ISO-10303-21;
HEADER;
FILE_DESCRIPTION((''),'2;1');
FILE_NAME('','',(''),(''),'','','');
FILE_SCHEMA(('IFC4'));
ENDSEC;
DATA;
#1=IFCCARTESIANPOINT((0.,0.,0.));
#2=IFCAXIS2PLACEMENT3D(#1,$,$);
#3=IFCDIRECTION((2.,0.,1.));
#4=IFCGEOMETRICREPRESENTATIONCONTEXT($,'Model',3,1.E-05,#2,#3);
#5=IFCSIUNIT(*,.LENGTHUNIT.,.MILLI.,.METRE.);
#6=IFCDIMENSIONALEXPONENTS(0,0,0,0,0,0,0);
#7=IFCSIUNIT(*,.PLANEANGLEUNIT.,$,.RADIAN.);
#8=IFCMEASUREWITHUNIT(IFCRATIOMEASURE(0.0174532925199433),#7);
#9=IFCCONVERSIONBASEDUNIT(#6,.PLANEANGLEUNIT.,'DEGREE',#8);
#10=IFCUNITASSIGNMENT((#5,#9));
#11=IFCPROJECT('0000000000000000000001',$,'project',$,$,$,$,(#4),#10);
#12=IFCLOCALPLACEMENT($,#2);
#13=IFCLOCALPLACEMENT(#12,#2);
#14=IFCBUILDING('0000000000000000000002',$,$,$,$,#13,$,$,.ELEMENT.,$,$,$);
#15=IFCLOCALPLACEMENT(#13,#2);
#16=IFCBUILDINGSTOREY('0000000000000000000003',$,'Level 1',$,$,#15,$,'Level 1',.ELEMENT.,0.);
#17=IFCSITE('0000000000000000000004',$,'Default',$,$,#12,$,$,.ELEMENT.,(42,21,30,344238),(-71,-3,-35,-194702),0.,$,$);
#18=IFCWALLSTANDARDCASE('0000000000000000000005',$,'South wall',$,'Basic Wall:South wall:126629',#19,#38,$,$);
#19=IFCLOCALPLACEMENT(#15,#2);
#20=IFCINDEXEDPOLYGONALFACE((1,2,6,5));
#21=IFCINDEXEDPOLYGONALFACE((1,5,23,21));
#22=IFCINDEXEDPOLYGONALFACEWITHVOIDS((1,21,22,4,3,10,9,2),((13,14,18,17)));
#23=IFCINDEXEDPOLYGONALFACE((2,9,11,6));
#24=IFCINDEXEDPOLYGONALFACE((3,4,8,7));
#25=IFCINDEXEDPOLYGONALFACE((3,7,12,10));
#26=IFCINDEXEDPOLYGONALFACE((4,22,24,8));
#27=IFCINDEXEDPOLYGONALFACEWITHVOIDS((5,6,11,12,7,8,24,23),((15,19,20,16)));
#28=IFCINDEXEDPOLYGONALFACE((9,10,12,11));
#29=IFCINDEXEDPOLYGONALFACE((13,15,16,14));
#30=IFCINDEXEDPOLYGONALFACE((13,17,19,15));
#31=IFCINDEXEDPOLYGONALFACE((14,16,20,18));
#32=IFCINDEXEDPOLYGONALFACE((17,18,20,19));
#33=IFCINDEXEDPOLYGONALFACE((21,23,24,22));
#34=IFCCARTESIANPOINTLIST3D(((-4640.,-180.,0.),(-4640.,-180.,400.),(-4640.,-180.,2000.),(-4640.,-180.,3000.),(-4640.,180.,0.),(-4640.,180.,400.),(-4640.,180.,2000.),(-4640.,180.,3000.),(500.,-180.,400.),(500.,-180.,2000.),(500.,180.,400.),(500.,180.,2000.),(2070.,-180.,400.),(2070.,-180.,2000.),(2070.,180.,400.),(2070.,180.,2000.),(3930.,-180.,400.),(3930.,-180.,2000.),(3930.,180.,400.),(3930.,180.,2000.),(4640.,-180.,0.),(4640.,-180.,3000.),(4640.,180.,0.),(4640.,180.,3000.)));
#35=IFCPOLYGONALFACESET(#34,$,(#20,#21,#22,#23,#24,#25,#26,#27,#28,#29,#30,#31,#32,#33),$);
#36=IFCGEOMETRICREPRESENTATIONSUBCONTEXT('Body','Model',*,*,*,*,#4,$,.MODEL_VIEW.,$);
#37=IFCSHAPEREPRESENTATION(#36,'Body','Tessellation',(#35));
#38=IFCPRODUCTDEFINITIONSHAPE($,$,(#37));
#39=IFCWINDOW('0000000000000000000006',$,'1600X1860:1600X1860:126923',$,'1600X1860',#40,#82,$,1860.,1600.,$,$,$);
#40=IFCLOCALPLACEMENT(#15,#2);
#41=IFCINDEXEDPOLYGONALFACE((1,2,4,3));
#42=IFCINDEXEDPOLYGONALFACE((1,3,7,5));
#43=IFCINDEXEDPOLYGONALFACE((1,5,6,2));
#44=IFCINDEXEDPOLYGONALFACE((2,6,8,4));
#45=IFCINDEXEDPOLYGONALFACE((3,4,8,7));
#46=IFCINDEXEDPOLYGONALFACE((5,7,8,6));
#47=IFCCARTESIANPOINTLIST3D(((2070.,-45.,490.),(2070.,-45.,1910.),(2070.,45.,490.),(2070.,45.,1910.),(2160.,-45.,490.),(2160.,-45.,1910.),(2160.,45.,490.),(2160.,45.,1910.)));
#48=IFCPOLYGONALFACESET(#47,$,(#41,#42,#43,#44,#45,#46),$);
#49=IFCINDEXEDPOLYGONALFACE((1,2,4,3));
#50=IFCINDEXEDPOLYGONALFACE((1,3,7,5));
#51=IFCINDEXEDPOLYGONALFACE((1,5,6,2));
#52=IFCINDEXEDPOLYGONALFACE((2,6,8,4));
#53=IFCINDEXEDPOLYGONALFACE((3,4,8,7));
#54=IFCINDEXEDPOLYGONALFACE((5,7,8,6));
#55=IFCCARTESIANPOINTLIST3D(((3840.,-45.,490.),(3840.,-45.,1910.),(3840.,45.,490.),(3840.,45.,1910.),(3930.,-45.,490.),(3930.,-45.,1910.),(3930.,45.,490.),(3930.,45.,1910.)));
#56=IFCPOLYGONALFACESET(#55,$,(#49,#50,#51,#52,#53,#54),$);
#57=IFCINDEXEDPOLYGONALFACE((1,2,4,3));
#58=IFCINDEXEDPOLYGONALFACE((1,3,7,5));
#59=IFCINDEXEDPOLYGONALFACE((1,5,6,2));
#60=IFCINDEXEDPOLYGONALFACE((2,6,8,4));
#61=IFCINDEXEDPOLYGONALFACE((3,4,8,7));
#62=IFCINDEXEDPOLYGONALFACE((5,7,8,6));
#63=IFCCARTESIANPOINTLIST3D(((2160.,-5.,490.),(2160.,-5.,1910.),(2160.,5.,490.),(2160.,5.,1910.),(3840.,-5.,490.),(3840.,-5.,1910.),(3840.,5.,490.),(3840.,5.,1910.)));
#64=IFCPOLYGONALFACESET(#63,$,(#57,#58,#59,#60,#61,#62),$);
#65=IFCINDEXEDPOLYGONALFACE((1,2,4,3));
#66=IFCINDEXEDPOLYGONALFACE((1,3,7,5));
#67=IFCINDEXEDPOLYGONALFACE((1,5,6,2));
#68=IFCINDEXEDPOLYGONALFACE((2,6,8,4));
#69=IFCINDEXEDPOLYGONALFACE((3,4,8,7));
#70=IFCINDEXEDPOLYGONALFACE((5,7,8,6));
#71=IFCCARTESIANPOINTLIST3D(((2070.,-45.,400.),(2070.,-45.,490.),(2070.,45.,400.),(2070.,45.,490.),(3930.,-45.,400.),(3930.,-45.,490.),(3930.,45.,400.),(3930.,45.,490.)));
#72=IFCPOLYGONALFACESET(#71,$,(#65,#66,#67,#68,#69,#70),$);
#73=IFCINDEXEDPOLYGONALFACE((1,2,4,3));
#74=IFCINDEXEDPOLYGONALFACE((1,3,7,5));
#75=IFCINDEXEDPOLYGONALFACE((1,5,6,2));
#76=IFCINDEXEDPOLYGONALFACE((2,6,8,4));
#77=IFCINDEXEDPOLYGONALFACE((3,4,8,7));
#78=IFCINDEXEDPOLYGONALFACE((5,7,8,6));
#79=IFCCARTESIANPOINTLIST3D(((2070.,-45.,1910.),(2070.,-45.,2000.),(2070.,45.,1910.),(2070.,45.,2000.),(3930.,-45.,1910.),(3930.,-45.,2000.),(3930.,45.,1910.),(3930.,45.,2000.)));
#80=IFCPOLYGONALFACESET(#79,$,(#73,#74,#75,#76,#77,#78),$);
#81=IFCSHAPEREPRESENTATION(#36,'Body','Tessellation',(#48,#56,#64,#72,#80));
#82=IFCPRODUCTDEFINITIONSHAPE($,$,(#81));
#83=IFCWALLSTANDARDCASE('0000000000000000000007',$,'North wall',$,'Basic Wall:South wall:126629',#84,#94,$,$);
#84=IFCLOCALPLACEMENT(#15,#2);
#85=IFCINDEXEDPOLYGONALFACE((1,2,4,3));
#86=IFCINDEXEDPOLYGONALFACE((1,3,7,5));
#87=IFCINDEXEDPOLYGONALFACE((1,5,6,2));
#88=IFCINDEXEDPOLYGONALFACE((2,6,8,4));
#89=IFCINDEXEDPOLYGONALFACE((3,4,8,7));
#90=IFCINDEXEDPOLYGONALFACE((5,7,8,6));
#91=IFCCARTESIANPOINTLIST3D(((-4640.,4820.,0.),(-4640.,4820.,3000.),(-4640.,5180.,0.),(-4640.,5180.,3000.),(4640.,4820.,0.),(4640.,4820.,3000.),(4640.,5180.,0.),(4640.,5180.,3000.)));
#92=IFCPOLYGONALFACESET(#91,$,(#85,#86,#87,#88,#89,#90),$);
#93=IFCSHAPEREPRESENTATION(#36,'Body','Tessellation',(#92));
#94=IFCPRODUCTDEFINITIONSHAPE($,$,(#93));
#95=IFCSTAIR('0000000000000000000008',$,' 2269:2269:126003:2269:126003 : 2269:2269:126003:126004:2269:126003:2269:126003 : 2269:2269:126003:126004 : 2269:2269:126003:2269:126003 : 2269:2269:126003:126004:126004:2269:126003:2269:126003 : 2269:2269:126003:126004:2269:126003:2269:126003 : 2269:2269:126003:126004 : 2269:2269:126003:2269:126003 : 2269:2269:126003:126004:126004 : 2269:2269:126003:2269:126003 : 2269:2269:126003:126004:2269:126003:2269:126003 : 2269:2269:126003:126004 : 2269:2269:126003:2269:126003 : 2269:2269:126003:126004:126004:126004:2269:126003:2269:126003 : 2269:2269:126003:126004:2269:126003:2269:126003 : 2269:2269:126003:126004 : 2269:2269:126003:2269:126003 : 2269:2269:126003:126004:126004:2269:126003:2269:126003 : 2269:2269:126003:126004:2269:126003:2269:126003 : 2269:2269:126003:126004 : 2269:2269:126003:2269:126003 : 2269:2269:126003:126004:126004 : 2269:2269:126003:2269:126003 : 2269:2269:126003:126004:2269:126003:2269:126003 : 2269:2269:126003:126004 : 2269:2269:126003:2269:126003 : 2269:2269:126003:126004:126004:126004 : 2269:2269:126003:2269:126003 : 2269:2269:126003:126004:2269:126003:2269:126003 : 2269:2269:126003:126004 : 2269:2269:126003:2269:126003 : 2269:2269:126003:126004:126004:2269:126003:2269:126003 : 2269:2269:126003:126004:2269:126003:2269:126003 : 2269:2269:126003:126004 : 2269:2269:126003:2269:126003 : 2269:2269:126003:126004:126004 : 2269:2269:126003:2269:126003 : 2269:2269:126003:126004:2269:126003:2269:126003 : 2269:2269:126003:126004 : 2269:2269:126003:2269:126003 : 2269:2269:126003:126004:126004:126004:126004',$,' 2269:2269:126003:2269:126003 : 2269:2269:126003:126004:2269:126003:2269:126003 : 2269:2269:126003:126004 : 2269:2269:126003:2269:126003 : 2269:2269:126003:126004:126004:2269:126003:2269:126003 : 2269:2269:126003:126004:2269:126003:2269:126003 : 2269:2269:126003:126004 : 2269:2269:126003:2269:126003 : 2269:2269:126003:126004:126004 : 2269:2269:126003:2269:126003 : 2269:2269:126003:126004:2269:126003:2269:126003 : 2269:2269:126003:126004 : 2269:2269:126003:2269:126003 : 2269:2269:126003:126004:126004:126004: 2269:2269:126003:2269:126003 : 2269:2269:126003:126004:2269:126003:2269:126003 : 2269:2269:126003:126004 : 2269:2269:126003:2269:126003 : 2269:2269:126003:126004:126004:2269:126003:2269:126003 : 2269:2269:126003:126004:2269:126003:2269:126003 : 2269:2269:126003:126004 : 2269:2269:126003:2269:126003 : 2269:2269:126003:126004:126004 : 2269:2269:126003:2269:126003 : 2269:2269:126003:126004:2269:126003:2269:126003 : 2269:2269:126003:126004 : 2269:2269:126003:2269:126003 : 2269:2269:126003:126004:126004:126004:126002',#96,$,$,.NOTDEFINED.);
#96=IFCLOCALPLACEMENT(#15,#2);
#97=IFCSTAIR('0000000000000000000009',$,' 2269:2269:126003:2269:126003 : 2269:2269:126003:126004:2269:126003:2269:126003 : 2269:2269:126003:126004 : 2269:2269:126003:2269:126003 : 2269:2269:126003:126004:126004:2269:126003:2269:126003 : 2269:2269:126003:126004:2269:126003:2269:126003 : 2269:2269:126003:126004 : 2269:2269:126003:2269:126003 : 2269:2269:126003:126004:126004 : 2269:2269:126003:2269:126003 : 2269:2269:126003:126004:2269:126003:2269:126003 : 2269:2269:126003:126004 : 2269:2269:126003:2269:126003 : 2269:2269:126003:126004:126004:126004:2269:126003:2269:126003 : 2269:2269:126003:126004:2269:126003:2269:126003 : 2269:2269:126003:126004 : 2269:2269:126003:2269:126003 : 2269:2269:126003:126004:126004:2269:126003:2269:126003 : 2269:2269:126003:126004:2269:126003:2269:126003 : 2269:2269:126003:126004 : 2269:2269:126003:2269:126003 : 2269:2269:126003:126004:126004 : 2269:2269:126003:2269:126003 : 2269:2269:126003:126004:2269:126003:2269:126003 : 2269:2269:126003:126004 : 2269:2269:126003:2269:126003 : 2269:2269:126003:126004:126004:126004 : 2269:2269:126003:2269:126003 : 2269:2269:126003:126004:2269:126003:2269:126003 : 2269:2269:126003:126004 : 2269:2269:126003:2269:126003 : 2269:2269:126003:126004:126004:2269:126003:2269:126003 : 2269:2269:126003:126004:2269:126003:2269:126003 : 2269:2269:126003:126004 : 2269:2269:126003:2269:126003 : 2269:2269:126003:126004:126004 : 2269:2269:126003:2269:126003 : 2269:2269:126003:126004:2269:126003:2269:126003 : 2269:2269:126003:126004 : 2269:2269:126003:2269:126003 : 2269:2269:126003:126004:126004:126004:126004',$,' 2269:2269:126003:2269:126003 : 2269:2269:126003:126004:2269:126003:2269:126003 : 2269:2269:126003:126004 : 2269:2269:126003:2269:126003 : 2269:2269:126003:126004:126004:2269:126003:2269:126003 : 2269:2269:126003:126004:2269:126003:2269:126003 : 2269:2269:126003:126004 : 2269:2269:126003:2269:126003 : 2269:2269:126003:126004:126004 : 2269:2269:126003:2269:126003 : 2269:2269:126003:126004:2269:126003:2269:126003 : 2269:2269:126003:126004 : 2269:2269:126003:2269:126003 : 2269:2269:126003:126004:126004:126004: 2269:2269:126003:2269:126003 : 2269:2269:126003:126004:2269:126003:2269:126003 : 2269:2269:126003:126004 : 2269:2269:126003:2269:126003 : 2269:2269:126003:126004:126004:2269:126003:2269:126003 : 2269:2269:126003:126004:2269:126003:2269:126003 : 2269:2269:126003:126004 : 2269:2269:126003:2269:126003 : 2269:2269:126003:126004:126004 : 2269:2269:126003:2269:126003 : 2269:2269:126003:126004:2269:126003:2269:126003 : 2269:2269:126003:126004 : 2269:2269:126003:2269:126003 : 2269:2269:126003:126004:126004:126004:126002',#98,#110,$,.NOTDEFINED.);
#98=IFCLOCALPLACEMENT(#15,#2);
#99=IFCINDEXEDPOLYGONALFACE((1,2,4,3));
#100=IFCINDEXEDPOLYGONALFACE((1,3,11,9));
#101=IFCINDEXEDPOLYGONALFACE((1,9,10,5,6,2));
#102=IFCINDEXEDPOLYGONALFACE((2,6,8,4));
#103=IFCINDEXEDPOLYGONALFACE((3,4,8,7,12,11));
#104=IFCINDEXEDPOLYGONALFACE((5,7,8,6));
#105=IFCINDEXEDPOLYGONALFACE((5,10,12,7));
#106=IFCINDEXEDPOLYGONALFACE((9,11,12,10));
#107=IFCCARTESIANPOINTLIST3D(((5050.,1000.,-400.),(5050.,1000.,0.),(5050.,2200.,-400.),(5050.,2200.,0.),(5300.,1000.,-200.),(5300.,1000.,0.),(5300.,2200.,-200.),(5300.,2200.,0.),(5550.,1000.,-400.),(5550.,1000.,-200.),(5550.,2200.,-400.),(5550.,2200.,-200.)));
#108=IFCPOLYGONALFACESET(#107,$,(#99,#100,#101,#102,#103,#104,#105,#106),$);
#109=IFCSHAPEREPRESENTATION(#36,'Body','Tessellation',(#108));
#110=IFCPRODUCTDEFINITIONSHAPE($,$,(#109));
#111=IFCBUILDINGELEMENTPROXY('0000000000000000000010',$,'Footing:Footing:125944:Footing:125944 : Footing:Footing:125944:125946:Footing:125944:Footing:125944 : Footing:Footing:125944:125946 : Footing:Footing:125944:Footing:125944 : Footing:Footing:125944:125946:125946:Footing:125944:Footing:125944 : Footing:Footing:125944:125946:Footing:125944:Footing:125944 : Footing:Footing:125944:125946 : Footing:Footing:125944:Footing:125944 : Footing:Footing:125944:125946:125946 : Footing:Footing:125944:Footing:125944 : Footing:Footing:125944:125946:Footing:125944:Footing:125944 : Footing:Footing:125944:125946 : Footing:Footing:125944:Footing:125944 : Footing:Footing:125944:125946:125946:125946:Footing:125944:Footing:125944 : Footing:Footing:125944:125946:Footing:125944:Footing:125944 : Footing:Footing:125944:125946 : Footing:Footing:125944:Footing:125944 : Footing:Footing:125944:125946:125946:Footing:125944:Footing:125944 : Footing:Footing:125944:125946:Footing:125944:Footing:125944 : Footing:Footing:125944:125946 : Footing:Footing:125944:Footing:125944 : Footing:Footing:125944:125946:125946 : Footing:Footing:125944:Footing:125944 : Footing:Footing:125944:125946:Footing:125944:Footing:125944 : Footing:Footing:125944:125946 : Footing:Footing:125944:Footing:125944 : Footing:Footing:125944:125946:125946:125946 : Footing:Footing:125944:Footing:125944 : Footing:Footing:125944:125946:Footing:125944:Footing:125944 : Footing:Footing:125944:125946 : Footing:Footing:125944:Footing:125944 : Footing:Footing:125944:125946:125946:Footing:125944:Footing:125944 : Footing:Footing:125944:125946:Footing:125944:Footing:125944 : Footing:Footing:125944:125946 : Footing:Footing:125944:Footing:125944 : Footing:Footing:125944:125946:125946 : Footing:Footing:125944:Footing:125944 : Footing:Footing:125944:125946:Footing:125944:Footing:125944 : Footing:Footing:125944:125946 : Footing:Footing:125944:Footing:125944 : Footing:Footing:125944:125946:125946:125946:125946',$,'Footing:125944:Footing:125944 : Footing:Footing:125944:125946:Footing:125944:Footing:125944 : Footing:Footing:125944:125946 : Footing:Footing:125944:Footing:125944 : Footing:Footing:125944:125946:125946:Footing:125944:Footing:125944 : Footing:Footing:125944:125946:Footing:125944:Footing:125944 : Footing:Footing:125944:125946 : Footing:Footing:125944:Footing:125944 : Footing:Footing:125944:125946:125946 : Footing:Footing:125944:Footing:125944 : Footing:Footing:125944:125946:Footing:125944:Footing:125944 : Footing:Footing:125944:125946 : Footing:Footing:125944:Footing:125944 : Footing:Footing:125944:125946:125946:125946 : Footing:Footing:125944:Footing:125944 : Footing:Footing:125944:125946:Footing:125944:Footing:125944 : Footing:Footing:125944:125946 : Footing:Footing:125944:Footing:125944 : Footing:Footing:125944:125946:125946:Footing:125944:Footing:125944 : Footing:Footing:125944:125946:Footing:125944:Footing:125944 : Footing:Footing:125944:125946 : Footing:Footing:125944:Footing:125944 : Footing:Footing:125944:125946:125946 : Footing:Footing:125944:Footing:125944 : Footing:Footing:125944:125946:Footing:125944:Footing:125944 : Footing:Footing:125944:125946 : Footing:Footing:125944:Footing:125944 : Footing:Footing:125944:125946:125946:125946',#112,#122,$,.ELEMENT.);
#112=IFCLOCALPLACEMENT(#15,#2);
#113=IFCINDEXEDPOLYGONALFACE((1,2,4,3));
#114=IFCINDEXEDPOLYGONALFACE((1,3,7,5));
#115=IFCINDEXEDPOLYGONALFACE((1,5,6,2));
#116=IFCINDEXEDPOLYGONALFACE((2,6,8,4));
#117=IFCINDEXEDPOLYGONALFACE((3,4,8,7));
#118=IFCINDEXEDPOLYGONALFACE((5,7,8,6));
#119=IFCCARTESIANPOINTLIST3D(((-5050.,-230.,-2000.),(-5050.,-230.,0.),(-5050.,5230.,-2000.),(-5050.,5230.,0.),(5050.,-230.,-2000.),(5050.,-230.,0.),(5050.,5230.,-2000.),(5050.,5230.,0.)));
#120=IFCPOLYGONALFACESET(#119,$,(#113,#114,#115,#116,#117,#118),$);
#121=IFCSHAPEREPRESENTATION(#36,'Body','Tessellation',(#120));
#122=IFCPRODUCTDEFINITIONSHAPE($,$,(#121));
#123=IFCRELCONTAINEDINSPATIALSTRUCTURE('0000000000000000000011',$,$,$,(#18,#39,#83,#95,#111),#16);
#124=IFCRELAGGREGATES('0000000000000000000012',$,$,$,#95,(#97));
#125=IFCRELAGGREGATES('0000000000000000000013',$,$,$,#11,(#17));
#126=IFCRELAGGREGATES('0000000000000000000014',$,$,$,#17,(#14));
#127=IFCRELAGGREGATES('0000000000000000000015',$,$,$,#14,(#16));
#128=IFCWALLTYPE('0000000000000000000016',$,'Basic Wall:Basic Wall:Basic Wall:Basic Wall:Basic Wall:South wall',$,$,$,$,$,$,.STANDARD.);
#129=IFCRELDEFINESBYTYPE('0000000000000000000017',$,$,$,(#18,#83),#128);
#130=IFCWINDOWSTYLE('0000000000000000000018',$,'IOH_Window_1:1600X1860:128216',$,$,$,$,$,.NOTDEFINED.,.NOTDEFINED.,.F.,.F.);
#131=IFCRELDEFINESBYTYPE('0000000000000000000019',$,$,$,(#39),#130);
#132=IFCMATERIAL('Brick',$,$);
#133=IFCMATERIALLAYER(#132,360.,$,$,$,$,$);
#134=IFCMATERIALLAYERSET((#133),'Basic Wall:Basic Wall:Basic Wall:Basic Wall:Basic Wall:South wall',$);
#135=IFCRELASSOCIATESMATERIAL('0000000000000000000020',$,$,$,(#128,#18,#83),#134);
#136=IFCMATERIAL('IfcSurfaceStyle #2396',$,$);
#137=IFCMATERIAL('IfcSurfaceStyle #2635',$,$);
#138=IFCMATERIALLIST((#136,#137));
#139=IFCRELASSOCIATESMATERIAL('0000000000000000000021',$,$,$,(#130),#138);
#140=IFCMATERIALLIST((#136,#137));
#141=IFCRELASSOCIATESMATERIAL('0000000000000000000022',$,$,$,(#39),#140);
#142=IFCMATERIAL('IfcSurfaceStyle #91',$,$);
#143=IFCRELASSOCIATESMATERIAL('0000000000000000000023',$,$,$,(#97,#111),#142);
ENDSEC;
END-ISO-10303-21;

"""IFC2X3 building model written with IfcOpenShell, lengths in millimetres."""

from ifc_helpers import new_model, entity, si_unit, converted_unit, direction, frame, frame_2d, origin, origin_2d_with_axis, place, context, subcontext, project, spatial, polyline, rectangle, outline, extrude, source, transform, mapped, material, material_list, layer, layer_set, layer_usage, type_object, type_shapes, element, fill, aggregate, save


model = new_model("IFC2X3")

# Units and contexts
model_context = context("Model", 3, precision=1e-05, world=origin(), true_north=direction((2.0, 0.0, 1.0)))
body_context = subcontext(model_context, "Body", "Model", "MODEL_VIEW")
ifc_project = project(units=[si_unit("LENGTHUNIT", "METRE", prefix="MILLI"), converted_unit("PLANEANGLEUNIT", "DEGREE", entity("IfcRatioMeasure", 0.0174532925199433), si_unit("PLANEANGLEUNIT", "RADIAN"), dimensions=[0, 0, 0, 0, 0, 0, 0])], contexts=[model_context])

# Site, building, storey
site_placement = place(None, origin())
site = spatial("IfcSite", under=ifc_project, at=site_placement, Name="Default", CompositionType="ELEMENT", RefLatitude=(42, 21, 30, 344238), RefLongitude=(-71, -3, -35, -194702), RefElevation=0.0)
building_placement = place(site_placement, origin())
building = spatial("IfcBuilding", under=site, at=building_placement, CompositionType="ELEMENT")
storey_placement = place(building_placement, origin())
storey = spatial("IfcBuildingStorey", under=building, at=storey_placement, Name="Level 1", LongName="Level 1", CompositionType="ELEMENT", Elevation=0.0)

# Shared definitions
ifc_material_1 = material(Name="IfcSurfaceStyle #2396")

# Shared definitions
ifc_material_2 = material(Name="Brick")
ifc_layer = layer(ifc_material_2, 360.0)
ifc_layer_set = layer_set([ifc_layer], Name="Basic Wall:Basic Wall:Basic Wall:Basic Wall:Basic Wall:South wall")
wall_type = type_object("IfcWallType", Name="Basic Wall:Basic Wall:Basic Wall:Basic Wall:Basic Wall:South wall", PredefinedType="STANDARD", material=ifc_layer_set)

# Wall, openings, window
ifc_layer_usage_1 = layer_usage(ifc_layer_set, "AXIS2", "NEGATIVE", 180.0)
wall_1_placement = place(storey_placement, frame((4640.0, 0.0, 0.0), z_axis=(0.0, 0.0, 1.0), x_axis=(-1.0, 0.0, 0.0)))
wall_1 = element("IfcWallStandardCase", 1, at=wall_1_placement, inside=storey, type_object=wall_type, material=ifc_layer_usage_1, Name="South wall", ObjectType="Basic Wall:South wall:126629", context=body_context, shape_type="SweptSolid", body=[
    extrude(rectangle(XDim=9280.0, YDim=360.0, at=frame_2d((4640.0, 0.0), x_axis=(-1.0, 0.0))), origin(), (0.0, 0.0, 1.0), 3000.0),
])
opening_1_placement = place(wall_1_placement, frame((10140.0, 180.0, 400.0)))
element("IfcOpeningElement", 2, at=opening_1_placement, cuts=wall_1, ObjectType="Opening", context=body_context, shape_type="SweptSolid", body=[
    extrude(rectangle(XDim=1600.0, YDim=6000.0, at=origin_2d_with_axis()), frame((-3000.0, -360.0, 800.0), z_axis=(0.0, 1.0, 0.0), x_axis=(0.0, 0.0, -1.0)), (0.0, 0.0, 1.0), 360.0),
])
opening_2_placement = place(wall_1_placement, frame((2570.0, 183.6, 400.0), z_axis=(0.0, 0.0, 1.0), x_axis=(-1.0, 0.0, 0.0)))
opening_2 = element("IfcOpeningElement", 3, at=opening_2_placement, cuts=wall_1, ObjectType="Opening", context=body_context, shape_type="SweptSolid", body=[
    extrude(rectangle(XDim=1600.0, YDim=1860.0, at=frame_2d((0.0, 0.0), x_axis=(1.0, 0.0))), frame((930.0, 367.2, 800.0), z_axis=(0.0, -1.0, 0.0), x_axis=(0.0, 0.0, -1.0)), (0.0, 0.0, 1.0), 367.2),
])
ifc_material_3 = material(Name="IfcSurfaceStyle #2635")
ifc_material_list_1 = material_list([ifc_material_1, ifc_material_3])
ifc_material_list_2 = material_list([ifc_material_1, ifc_material_3])
window_style_1 = type_object("IfcWindowStyle", Name="IOH_Window_1:1600X1860:128216", ConstructionType="NOTDEFINED", OperationType="NOTDEFINED", ParameterTakesPrecedence=False, Sizeable=False, material=ifc_material_list_2)
shared_shape_1 = source(origin(), body_context, "Body", "SweptSolid", [
    extrude(rectangle(XDim=90.0, YDim=90.0, at=frame_2d((0.0, 0.0), x_axis=(1.0, 0.0))), frame((45.0, 183.6, 90.0), z_axis=(0.0, 0.0, 1.0), x_axis=(-1.0, 0.0, 0.0)), (0.0, 0.0, 1.0), 1420.0),
    extrude(rectangle(XDim=90.0, YDim=90.0, at=frame_2d((0.0, 0.0), x_axis=(1.0, 0.0))), frame((1815.0, 183.6, 90.0), z_axis=(0.0, 0.0, 1.0), x_axis=(-1.0, 0.0, 0.0)), (0.0, 0.0, 1.0), 1420.0),
    extrude(rectangle(XDim=1680.0, YDim=10.0, at=origin_2d_with_axis()), frame((930.0, 183.6, 90.0), z_axis=(0.0, 0.0, 1.0), x_axis=(-1.0, 0.0, 0.0)), (0.0, 0.0, 1.0), 1420.0),
    extrude(rectangle(XDim=90.0, YDim=1860.0, at=origin_2d_with_axis()), frame((930.0, 183.6, 0.0), z_axis=(0.0, 0.0, 1.0), x_axis=(0.0, 1.0, 0.0)), (0.0, 0.0, 1.0), 90.0),
    extrude(rectangle(XDim=90.0, YDim=1860.0, at=origin_2d_with_axis()), frame((930.0, 183.6, 1510.0), z_axis=(0.0, 0.0, 1.0), x_axis=(0.0, 1.0, 0.0)), (0.0, 0.0, 1.0), 90.0),
])
type_shapes(window_style_1, [shared_shape_1])
window_1_placement = place(storey_placement, frame((2070.0, -183.6, 400.0)))
window_1 = element("IfcWindow", 4, at=window_1_placement, inside=storey, type_object=window_style_1, material=ifc_material_list_1, Name="1600X1860:1600X1860:126923", ObjectType="1600X1860", OverallHeight=1860.0, OverallWidth=1600.0, context=body_context, shape_type="MappedRepresentation", body=[
    mapped(shared_shape_1, transform((0.0, 0.0, 0.0), scale=1.0)),
])
fill(opening_2, window_1)

# Wall
ifc_layer_usage_2 = layer_usage(ifc_layer_set, "AXIS2", "NEGATIVE", 180.0)
wall_2_placement = place(storey_placement, frame((4640.0, 5000.0, 0.0), z_axis=(0.0, 0.0, 1.0), x_axis=(-1.0, 0.0, 0.0)))
element("IfcWallStandardCase", 5, at=wall_2_placement, inside=storey, type_object=wall_type, material=ifc_layer_usage_2, Name="North wall", ObjectType="Basic Wall:South wall:126629", context=body_context, shape_type="SweptSolid", body=[
    extrude(rectangle(XDim=9280.0, YDim=360.0, at=frame_2d((4640.0, 0.0), x_axis=(-1.0, 0.0))), origin(), (0.0, 0.0, 1.0), 3000.0),
])

# Stairs
stair_1_placement = place(storey_placement, frame((5050.0, 1000.0, -400.0)))
stair_1 = element("IfcStair", 6, at=stair_1_placement, inside=storey, Name=" 2269:2269:126003:2269:126003 : 2269:2269:126003:126004:2269:126003:2269:126003 : 2269:2269:126003:126004 : 2269:2269:126003:2269:126003 : 2269:2269:126003:126004:126004:2269:126003:2269:126003 : 2269:2269:126003:126004:2269:126003:2269:126003 : 2269:2269:126003:126004 : 2269:2269:126003:2269:126003 : 2269:2269:126003:126004:126004 : 2269:2269:126003:2269:126003 : 2269:2269:126003:126004:2269:126003:2269:126003 : 2269:2269:126003:126004 : 2269:2269:126003:2269:126003 : 2269:2269:126003:126004:126004:126004:2269:126003:2269:126003 : 2269:2269:126003:126004:2269:126003:2269:126003 : 2269:2269:126003:126004 : 2269:2269:126003:2269:126003 : 2269:2269:126003:126004:126004:2269:126003:2269:126003 : 2269:2269:126003:126004:2269:126003:2269:126003 : 2269:2269:126003:126004 : 2269:2269:126003:2269:126003 : 2269:2269:126003:126004:126004 : 2269:2269:126003:2269:126003 : 2269:2269:126003:126004:2269:126003:2269:126003 : 2269:2269:126003:126004 : 2269:2269:126003:2269:126003 : 2269:2269:126003:126004:126004:126004 : 2269:2269:126003:2269:126003 : 2269:2269:126003:126004:2269:126003:2269:126003 : 2269:2269:126003:126004 : 2269:2269:126003:2269:126003 : 2269:2269:126003:126004:126004:2269:126003:2269:126003 : 2269:2269:126003:126004:2269:126003:2269:126003 : 2269:2269:126003:126004 : 2269:2269:126003:2269:126003 : 2269:2269:126003:126004:126004 : 2269:2269:126003:2269:126003 : 2269:2269:126003:126004:2269:126003:2269:126003 : 2269:2269:126003:126004 : 2269:2269:126003:2269:126003 : 2269:2269:126003:126004:126004:126004:126004", ObjectType=" 2269:2269:126003:2269:126003 : 2269:2269:126003:126004:2269:126003:2269:126003 : 2269:2269:126003:126004 : 2269:2269:126003:2269:126003 : 2269:2269:126003:126004:126004:2269:126003:2269:126003 : 2269:2269:126003:126004:2269:126003:2269:126003 : 2269:2269:126003:126004 : 2269:2269:126003:2269:126003 : 2269:2269:126003:126004:126004 : 2269:2269:126003:2269:126003 : 2269:2269:126003:126004:2269:126003:2269:126003 : 2269:2269:126003:126004 : 2269:2269:126003:2269:126003 : 2269:2269:126003:126004:126004:126004: 2269:2269:126003:2269:126003 : 2269:2269:126003:126004:2269:126003:2269:126003 : 2269:2269:126003:126004 : 2269:2269:126003:2269:126003 : 2269:2269:126003:126004:126004:2269:126003:2269:126003 : 2269:2269:126003:126004:2269:126003:2269:126003 : 2269:2269:126003:126004 : 2269:2269:126003:2269:126003 : 2269:2269:126003:126004:126004 : 2269:2269:126003:2269:126003 : 2269:2269:126003:126004:2269:126003:2269:126003 : 2269:2269:126003:126004 : 2269:2269:126003:2269:126003 : 2269:2269:126003:126004:126004:126004:126002", ShapeType="NOTDEFINED")
ifc_material_4 = material(Name="IfcSurfaceStyle #91")
stair_2_placement = place(stair_1_placement, origin())
stair_2 = element("IfcStair", 7, at=stair_2_placement, material=ifc_material_4, Name=" 2269:2269:126003:2269:126003 : 2269:2269:126003:126004:2269:126003:2269:126003 : 2269:2269:126003:126004 : 2269:2269:126003:2269:126003 : 2269:2269:126003:126004:126004:2269:126003:2269:126003 : 2269:2269:126003:126004:2269:126003:2269:126003 : 2269:2269:126003:126004 : 2269:2269:126003:2269:126003 : 2269:2269:126003:126004:126004 : 2269:2269:126003:2269:126003 : 2269:2269:126003:126004:2269:126003:2269:126003 : 2269:2269:126003:126004 : 2269:2269:126003:2269:126003 : 2269:2269:126003:126004:126004:126004:2269:126003:2269:126003 : 2269:2269:126003:126004:2269:126003:2269:126003 : 2269:2269:126003:126004 : 2269:2269:126003:2269:126003 : 2269:2269:126003:126004:126004:2269:126003:2269:126003 : 2269:2269:126003:126004:2269:126003:2269:126003 : 2269:2269:126003:126004 : 2269:2269:126003:2269:126003 : 2269:2269:126003:126004:126004 : 2269:2269:126003:2269:126003 : 2269:2269:126003:126004:2269:126003:2269:126003 : 2269:2269:126003:126004 : 2269:2269:126003:2269:126003 : 2269:2269:126003:126004:126004:126004 : 2269:2269:126003:2269:126003 : 2269:2269:126003:126004:2269:126003:2269:126003 : 2269:2269:126003:126004 : 2269:2269:126003:2269:126003 : 2269:2269:126003:126004:126004:2269:126003:2269:126003 : 2269:2269:126003:126004:2269:126003:2269:126003 : 2269:2269:126003:126004 : 2269:2269:126003:2269:126003 : 2269:2269:126003:126004:126004 : 2269:2269:126003:2269:126003 : 2269:2269:126003:126004:2269:126003:2269:126003 : 2269:2269:126003:126004 : 2269:2269:126003:2269:126003 : 2269:2269:126003:126004:126004:126004:126004", ObjectType=" 2269:2269:126003:2269:126003 : 2269:2269:126003:126004:2269:126003:2269:126003 : 2269:2269:126003:126004 : 2269:2269:126003:2269:126003 : 2269:2269:126003:126004:126004:2269:126003:2269:126003 : 2269:2269:126003:126004:2269:126003:2269:126003 : 2269:2269:126003:126004 : 2269:2269:126003:2269:126003 : 2269:2269:126003:126004:126004 : 2269:2269:126003:2269:126003 : 2269:2269:126003:126004:2269:126003:2269:126003 : 2269:2269:126003:126004 : 2269:2269:126003:2269:126003 : 2269:2269:126003:126004:126004:126004: 2269:2269:126003:2269:126003 : 2269:2269:126003:126004:2269:126003:2269:126003 : 2269:2269:126003:126004 : 2269:2269:126003:2269:126003 : 2269:2269:126003:126004:126004:2269:126003:2269:126003 : 2269:2269:126003:126004:2269:126003:2269:126003 : 2269:2269:126003:126004 : 2269:2269:126003:2269:126003 : 2269:2269:126003:126004:126004 : 2269:2269:126003:2269:126003 : 2269:2269:126003:126004:2269:126003:2269:126003 : 2269:2269:126003:126004 : 2269:2269:126003:2269:126003 : 2269:2269:126003:126004:126004:126004:126002", ShapeType="NOTDEFINED", context=body_context, shape_type="SweptSolid", body=[
    extrude(outline(polyline([(-200.0, -250.0), (200.0, -250.0), (200.0, 0.0), (0.0, 0.0), (0.0, 250.0), (-200.0, 250.0), (-200.0, -250.0)])), frame((250.0, 0.0, 200.0), z_axis=(0.0, 1.0, 0.0), x_axis=(0.0, 0.0, 1.0)), (0.0, 0.0, 1.0), 1200.0),
])
aggregate(stair_1, [stair_2])

# Building element proxy
shared_shape_2 = source(origin(), body_context, "Body", "SweptSolid", [
    extrude(rectangle(XDim=5460.0, YDim=10100.0, at=origin_2d_with_axis()), frame((0.0, 2500.0, -2000.0), z_axis=(0.0, 0.0, 1.0), x_axis=(0.0, 1.0, 0.0)), (0.0, 0.0, 1.0), 2000.0),
])
proxy_placement = place(storey_placement, origin())
element("IfcBuildingElementProxy", 8, at=proxy_placement, inside=storey, material=ifc_material_4, Name="Footing:Footing:125944:Footing:125944 : Footing:Footing:125944:125946:Footing:125944:Footing:125944 : Footing:Footing:125944:125946 : Footing:Footing:125944:Footing:125944 : Footing:Footing:125944:125946:125946:Footing:125944:Footing:125944 : Footing:Footing:125944:125946:Footing:125944:Footing:125944 : Footing:Footing:125944:125946 : Footing:Footing:125944:Footing:125944 : Footing:Footing:125944:125946:125946 : Footing:Footing:125944:Footing:125944 : Footing:Footing:125944:125946:Footing:125944:Footing:125944 : Footing:Footing:125944:125946 : Footing:Footing:125944:Footing:125944 : Footing:Footing:125944:125946:125946:125946:Footing:125944:Footing:125944 : Footing:Footing:125944:125946:Footing:125944:Footing:125944 : Footing:Footing:125944:125946 : Footing:Footing:125944:Footing:125944 : Footing:Footing:125944:125946:125946:Footing:125944:Footing:125944 : Footing:Footing:125944:125946:Footing:125944:Footing:125944 : Footing:Footing:125944:125946 : Footing:Footing:125944:Footing:125944 : Footing:Footing:125944:125946:125946 : Footing:Footing:125944:Footing:125944 : Footing:Footing:125944:125946:Footing:125944:Footing:125944 : Footing:Footing:125944:125946 : Footing:Footing:125944:Footing:125944 : Footing:Footing:125944:125946:125946:125946 : Footing:Footing:125944:Footing:125944 : Footing:Footing:125944:125946:Footing:125944:Footing:125944 : Footing:Footing:125944:125946 : Footing:Footing:125944:Footing:125944 : Footing:Footing:125944:125946:125946:Footing:125944:Footing:125944 : Footing:Footing:125944:125946:Footing:125944:Footing:125944 : Footing:Footing:125944:125946 : Footing:Footing:125944:Footing:125944 : Footing:Footing:125944:125946:125946 : Footing:Footing:125944:Footing:125944 : Footing:Footing:125944:125946:Footing:125944:Footing:125944 : Footing:Footing:125944:125946 : Footing:Footing:125944:Footing:125944 : Footing:Footing:125944:125946:125946:125946:125946", ObjectType="Footing:125944:Footing:125944 : Footing:Footing:125944:125946:Footing:125944:Footing:125944 : Footing:Footing:125944:125946 : Footing:Footing:125944:Footing:125944 : Footing:Footing:125944:125946:125946:Footing:125944:Footing:125944 : Footing:Footing:125944:125946:Footing:125944:Footing:125944 : Footing:Footing:125944:125946 : Footing:Footing:125944:Footing:125944 : Footing:Footing:125944:125946:125946 : Footing:Footing:125944:Footing:125944 : Footing:Footing:125944:125946:Footing:125944:Footing:125944 : Footing:Footing:125944:125946 : Footing:Footing:125944:Footing:125944 : Footing:Footing:125944:125946:125946:125946 : Footing:Footing:125944:Footing:125944 : Footing:Footing:125944:125946:Footing:125944:Footing:125944 : Footing:Footing:125944:125946 : Footing:Footing:125944:Footing:125944 : Footing:Footing:125944:125946:125946:Footing:125944:Footing:125944 : Footing:Footing:125944:125946:Footing:125944:Footing:125944 : Footing:Footing:125944:125946 : Footing:Footing:125944:Footing:125944 : Footing:Footing:125944:125946:125946 : Footing:Footing:125944:Footing:125944 : Footing:Footing:125944:125946:Footing:125944:Footing:125944 : Footing:Footing:125944:125946 : Footing:Footing:125944:Footing:125944 : Footing:Footing:125944:125946:125946:125946", CompositionType="ELEMENT", context=body_context, shape_type="MappedRepresentation", body=[
    mapped(shared_shape_2, transform((0.0, 0.0, 0.0), scale=1.0)),
])

save(model, "model.ifc")
